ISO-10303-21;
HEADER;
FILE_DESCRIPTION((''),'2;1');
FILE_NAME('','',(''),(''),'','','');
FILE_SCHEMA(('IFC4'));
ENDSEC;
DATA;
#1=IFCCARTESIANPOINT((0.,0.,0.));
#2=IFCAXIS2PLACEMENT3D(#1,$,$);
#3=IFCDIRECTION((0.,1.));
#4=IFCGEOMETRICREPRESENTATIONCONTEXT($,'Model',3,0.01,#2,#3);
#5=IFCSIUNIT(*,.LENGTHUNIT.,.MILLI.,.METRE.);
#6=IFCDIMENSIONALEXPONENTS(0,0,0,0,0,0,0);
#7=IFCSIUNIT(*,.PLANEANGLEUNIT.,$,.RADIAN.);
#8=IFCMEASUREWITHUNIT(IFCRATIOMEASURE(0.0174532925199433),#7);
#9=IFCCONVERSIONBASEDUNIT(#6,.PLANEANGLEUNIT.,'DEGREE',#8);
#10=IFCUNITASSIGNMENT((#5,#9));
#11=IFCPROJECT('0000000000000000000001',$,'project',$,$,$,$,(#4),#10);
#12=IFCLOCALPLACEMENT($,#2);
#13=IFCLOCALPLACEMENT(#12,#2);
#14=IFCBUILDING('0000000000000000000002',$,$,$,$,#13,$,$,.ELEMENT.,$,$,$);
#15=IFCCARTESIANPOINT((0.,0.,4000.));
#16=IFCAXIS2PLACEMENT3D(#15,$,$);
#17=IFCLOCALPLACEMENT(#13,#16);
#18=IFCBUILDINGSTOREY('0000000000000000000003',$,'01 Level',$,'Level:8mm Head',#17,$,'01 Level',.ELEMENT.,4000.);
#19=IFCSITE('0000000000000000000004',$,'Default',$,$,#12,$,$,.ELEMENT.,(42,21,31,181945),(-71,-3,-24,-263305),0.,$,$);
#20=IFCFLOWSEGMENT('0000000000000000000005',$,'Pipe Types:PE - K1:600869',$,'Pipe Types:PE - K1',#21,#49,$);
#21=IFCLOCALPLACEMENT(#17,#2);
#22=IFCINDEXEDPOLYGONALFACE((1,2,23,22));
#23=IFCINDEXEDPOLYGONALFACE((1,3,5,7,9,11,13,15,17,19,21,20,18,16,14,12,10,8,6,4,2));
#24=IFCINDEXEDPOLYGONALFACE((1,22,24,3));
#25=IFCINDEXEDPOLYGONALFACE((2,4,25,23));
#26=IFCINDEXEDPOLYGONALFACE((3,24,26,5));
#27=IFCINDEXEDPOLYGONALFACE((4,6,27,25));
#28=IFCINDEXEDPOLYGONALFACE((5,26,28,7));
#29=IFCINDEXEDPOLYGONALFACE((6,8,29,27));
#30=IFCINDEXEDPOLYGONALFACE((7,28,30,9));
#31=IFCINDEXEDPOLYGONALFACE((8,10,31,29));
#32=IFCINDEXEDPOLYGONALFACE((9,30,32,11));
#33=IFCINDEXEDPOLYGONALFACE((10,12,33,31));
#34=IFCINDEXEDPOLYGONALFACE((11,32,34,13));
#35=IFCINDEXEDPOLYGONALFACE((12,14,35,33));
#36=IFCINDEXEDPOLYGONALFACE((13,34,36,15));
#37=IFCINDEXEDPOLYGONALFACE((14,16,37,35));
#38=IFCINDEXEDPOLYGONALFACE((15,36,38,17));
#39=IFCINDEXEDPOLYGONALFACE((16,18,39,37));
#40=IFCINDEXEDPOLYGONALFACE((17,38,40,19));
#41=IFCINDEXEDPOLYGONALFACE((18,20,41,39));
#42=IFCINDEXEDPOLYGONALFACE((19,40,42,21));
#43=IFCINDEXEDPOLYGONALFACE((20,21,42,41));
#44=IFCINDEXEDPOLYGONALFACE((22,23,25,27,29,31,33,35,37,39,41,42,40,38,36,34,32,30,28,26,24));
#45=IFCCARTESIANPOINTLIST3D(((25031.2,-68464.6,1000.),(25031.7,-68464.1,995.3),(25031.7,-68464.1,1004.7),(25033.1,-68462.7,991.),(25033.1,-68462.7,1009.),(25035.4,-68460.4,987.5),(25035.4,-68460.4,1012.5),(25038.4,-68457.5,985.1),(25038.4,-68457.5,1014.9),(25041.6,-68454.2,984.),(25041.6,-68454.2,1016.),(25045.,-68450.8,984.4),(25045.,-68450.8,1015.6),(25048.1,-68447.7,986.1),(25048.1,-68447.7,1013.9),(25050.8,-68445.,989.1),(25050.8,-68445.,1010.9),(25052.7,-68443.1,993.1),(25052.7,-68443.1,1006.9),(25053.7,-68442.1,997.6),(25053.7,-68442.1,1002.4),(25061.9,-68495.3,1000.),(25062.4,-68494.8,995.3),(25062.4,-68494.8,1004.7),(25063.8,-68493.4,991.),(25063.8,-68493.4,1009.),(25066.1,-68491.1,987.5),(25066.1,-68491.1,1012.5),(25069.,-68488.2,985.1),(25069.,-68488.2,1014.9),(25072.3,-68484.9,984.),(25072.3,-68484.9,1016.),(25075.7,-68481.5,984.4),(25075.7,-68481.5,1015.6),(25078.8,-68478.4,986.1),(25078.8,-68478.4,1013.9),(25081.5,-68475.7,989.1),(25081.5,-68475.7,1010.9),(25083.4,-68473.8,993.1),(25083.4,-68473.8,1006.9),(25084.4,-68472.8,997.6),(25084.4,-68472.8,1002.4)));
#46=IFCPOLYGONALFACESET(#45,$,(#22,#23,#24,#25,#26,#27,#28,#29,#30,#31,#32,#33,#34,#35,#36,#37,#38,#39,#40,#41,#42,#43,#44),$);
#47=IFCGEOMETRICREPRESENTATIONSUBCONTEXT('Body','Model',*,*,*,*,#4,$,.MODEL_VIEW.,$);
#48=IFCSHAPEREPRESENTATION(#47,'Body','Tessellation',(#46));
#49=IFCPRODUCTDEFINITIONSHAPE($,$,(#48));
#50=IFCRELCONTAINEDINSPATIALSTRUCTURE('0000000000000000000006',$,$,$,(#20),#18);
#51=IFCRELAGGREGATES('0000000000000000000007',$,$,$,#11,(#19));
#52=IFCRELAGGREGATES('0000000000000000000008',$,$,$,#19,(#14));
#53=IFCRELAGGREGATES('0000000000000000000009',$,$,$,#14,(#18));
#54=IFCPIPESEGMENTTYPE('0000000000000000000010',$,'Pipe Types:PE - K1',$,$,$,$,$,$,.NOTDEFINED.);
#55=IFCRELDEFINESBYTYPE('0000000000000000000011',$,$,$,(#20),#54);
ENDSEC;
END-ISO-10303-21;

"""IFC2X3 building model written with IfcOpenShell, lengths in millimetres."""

from ifc_helpers import new_model, entity, si_unit, converted_unit, direction, frame, frame_2d, origin, place, context, subcontext, project, spatial, circle, extrude, type_object, element, save


model = new_model("IFC2X3")

# Units and contexts
model_context = context("Model", 3, precision=0.01, world=origin(), true_north=direction((0.0, 1.0)))
body_context = subcontext(model_context, "Body", "Model", "MODEL_VIEW")
ifc_project = project(units=[si_unit("LENGTHUNIT", "METRE", prefix="MILLI"), converted_unit("PLANEANGLEUNIT", "DEGREE", entity("IfcRatioMeasure", 0.0174532925199433), si_unit("PLANEANGLEUNIT", "RADIAN"), dimensions=[0, 0, 0, 0, 0, 0, 0])], contexts=[model_context])

# Site, building, storey
site_placement = place(None, origin())
site = spatial("IfcSite", under=ifc_project, at=site_placement, Name="Default", CompositionType="ELEMENT", RefLatitude=(42, 21, 31, 181945), RefLongitude=(-71, -3, -24, -263305), RefElevation=0.0)
building_placement = place(site_placement, origin())
building = spatial("IfcBuilding", under=site, at=building_placement, CompositionType="ELEMENT")
storey_placement = place(building_placement, frame((0.0, 0.0, 4000.0)))
storey = spatial("IfcBuildingStorey", under=building, at=storey_placement, Name="01 Level", ObjectType="Level:8mm Head", LongName="01 Level", CompositionType="ELEMENT", Elevation=4000.0)

# Flow segment
pipe_segment_type = type_object("IfcPipeSegmentType", Name="Pipe Types:PE - K1", PredefinedType="NOTDEFINED")
flow_segment_1_placement = place(storey_placement, frame((25029.6, -68496.9, 982.4)))
element("IfcFlowSegment", 1, at=flow_segment_1_placement, inside=storey, type_object=pipe_segment_type, Name="Pipe Types:PE - K1:600869", ObjectType="Pipe Types:PE - K1", context=body_context, shape_type="SweptSolid", body=[
    extrude(circle(Radius=16.0, at=frame_2d((0.0, 0.0), x_axis=(1.0, 0.0))), frame((43.6, 12.9, 17.6), z_axis=(-0.707107, 0.707107, 0.0), x_axis=(-0.707107, -0.707107, 0.0)), (0.0, 0.0, 1.0), 43.4),
])

save(model, "model.ifc")
